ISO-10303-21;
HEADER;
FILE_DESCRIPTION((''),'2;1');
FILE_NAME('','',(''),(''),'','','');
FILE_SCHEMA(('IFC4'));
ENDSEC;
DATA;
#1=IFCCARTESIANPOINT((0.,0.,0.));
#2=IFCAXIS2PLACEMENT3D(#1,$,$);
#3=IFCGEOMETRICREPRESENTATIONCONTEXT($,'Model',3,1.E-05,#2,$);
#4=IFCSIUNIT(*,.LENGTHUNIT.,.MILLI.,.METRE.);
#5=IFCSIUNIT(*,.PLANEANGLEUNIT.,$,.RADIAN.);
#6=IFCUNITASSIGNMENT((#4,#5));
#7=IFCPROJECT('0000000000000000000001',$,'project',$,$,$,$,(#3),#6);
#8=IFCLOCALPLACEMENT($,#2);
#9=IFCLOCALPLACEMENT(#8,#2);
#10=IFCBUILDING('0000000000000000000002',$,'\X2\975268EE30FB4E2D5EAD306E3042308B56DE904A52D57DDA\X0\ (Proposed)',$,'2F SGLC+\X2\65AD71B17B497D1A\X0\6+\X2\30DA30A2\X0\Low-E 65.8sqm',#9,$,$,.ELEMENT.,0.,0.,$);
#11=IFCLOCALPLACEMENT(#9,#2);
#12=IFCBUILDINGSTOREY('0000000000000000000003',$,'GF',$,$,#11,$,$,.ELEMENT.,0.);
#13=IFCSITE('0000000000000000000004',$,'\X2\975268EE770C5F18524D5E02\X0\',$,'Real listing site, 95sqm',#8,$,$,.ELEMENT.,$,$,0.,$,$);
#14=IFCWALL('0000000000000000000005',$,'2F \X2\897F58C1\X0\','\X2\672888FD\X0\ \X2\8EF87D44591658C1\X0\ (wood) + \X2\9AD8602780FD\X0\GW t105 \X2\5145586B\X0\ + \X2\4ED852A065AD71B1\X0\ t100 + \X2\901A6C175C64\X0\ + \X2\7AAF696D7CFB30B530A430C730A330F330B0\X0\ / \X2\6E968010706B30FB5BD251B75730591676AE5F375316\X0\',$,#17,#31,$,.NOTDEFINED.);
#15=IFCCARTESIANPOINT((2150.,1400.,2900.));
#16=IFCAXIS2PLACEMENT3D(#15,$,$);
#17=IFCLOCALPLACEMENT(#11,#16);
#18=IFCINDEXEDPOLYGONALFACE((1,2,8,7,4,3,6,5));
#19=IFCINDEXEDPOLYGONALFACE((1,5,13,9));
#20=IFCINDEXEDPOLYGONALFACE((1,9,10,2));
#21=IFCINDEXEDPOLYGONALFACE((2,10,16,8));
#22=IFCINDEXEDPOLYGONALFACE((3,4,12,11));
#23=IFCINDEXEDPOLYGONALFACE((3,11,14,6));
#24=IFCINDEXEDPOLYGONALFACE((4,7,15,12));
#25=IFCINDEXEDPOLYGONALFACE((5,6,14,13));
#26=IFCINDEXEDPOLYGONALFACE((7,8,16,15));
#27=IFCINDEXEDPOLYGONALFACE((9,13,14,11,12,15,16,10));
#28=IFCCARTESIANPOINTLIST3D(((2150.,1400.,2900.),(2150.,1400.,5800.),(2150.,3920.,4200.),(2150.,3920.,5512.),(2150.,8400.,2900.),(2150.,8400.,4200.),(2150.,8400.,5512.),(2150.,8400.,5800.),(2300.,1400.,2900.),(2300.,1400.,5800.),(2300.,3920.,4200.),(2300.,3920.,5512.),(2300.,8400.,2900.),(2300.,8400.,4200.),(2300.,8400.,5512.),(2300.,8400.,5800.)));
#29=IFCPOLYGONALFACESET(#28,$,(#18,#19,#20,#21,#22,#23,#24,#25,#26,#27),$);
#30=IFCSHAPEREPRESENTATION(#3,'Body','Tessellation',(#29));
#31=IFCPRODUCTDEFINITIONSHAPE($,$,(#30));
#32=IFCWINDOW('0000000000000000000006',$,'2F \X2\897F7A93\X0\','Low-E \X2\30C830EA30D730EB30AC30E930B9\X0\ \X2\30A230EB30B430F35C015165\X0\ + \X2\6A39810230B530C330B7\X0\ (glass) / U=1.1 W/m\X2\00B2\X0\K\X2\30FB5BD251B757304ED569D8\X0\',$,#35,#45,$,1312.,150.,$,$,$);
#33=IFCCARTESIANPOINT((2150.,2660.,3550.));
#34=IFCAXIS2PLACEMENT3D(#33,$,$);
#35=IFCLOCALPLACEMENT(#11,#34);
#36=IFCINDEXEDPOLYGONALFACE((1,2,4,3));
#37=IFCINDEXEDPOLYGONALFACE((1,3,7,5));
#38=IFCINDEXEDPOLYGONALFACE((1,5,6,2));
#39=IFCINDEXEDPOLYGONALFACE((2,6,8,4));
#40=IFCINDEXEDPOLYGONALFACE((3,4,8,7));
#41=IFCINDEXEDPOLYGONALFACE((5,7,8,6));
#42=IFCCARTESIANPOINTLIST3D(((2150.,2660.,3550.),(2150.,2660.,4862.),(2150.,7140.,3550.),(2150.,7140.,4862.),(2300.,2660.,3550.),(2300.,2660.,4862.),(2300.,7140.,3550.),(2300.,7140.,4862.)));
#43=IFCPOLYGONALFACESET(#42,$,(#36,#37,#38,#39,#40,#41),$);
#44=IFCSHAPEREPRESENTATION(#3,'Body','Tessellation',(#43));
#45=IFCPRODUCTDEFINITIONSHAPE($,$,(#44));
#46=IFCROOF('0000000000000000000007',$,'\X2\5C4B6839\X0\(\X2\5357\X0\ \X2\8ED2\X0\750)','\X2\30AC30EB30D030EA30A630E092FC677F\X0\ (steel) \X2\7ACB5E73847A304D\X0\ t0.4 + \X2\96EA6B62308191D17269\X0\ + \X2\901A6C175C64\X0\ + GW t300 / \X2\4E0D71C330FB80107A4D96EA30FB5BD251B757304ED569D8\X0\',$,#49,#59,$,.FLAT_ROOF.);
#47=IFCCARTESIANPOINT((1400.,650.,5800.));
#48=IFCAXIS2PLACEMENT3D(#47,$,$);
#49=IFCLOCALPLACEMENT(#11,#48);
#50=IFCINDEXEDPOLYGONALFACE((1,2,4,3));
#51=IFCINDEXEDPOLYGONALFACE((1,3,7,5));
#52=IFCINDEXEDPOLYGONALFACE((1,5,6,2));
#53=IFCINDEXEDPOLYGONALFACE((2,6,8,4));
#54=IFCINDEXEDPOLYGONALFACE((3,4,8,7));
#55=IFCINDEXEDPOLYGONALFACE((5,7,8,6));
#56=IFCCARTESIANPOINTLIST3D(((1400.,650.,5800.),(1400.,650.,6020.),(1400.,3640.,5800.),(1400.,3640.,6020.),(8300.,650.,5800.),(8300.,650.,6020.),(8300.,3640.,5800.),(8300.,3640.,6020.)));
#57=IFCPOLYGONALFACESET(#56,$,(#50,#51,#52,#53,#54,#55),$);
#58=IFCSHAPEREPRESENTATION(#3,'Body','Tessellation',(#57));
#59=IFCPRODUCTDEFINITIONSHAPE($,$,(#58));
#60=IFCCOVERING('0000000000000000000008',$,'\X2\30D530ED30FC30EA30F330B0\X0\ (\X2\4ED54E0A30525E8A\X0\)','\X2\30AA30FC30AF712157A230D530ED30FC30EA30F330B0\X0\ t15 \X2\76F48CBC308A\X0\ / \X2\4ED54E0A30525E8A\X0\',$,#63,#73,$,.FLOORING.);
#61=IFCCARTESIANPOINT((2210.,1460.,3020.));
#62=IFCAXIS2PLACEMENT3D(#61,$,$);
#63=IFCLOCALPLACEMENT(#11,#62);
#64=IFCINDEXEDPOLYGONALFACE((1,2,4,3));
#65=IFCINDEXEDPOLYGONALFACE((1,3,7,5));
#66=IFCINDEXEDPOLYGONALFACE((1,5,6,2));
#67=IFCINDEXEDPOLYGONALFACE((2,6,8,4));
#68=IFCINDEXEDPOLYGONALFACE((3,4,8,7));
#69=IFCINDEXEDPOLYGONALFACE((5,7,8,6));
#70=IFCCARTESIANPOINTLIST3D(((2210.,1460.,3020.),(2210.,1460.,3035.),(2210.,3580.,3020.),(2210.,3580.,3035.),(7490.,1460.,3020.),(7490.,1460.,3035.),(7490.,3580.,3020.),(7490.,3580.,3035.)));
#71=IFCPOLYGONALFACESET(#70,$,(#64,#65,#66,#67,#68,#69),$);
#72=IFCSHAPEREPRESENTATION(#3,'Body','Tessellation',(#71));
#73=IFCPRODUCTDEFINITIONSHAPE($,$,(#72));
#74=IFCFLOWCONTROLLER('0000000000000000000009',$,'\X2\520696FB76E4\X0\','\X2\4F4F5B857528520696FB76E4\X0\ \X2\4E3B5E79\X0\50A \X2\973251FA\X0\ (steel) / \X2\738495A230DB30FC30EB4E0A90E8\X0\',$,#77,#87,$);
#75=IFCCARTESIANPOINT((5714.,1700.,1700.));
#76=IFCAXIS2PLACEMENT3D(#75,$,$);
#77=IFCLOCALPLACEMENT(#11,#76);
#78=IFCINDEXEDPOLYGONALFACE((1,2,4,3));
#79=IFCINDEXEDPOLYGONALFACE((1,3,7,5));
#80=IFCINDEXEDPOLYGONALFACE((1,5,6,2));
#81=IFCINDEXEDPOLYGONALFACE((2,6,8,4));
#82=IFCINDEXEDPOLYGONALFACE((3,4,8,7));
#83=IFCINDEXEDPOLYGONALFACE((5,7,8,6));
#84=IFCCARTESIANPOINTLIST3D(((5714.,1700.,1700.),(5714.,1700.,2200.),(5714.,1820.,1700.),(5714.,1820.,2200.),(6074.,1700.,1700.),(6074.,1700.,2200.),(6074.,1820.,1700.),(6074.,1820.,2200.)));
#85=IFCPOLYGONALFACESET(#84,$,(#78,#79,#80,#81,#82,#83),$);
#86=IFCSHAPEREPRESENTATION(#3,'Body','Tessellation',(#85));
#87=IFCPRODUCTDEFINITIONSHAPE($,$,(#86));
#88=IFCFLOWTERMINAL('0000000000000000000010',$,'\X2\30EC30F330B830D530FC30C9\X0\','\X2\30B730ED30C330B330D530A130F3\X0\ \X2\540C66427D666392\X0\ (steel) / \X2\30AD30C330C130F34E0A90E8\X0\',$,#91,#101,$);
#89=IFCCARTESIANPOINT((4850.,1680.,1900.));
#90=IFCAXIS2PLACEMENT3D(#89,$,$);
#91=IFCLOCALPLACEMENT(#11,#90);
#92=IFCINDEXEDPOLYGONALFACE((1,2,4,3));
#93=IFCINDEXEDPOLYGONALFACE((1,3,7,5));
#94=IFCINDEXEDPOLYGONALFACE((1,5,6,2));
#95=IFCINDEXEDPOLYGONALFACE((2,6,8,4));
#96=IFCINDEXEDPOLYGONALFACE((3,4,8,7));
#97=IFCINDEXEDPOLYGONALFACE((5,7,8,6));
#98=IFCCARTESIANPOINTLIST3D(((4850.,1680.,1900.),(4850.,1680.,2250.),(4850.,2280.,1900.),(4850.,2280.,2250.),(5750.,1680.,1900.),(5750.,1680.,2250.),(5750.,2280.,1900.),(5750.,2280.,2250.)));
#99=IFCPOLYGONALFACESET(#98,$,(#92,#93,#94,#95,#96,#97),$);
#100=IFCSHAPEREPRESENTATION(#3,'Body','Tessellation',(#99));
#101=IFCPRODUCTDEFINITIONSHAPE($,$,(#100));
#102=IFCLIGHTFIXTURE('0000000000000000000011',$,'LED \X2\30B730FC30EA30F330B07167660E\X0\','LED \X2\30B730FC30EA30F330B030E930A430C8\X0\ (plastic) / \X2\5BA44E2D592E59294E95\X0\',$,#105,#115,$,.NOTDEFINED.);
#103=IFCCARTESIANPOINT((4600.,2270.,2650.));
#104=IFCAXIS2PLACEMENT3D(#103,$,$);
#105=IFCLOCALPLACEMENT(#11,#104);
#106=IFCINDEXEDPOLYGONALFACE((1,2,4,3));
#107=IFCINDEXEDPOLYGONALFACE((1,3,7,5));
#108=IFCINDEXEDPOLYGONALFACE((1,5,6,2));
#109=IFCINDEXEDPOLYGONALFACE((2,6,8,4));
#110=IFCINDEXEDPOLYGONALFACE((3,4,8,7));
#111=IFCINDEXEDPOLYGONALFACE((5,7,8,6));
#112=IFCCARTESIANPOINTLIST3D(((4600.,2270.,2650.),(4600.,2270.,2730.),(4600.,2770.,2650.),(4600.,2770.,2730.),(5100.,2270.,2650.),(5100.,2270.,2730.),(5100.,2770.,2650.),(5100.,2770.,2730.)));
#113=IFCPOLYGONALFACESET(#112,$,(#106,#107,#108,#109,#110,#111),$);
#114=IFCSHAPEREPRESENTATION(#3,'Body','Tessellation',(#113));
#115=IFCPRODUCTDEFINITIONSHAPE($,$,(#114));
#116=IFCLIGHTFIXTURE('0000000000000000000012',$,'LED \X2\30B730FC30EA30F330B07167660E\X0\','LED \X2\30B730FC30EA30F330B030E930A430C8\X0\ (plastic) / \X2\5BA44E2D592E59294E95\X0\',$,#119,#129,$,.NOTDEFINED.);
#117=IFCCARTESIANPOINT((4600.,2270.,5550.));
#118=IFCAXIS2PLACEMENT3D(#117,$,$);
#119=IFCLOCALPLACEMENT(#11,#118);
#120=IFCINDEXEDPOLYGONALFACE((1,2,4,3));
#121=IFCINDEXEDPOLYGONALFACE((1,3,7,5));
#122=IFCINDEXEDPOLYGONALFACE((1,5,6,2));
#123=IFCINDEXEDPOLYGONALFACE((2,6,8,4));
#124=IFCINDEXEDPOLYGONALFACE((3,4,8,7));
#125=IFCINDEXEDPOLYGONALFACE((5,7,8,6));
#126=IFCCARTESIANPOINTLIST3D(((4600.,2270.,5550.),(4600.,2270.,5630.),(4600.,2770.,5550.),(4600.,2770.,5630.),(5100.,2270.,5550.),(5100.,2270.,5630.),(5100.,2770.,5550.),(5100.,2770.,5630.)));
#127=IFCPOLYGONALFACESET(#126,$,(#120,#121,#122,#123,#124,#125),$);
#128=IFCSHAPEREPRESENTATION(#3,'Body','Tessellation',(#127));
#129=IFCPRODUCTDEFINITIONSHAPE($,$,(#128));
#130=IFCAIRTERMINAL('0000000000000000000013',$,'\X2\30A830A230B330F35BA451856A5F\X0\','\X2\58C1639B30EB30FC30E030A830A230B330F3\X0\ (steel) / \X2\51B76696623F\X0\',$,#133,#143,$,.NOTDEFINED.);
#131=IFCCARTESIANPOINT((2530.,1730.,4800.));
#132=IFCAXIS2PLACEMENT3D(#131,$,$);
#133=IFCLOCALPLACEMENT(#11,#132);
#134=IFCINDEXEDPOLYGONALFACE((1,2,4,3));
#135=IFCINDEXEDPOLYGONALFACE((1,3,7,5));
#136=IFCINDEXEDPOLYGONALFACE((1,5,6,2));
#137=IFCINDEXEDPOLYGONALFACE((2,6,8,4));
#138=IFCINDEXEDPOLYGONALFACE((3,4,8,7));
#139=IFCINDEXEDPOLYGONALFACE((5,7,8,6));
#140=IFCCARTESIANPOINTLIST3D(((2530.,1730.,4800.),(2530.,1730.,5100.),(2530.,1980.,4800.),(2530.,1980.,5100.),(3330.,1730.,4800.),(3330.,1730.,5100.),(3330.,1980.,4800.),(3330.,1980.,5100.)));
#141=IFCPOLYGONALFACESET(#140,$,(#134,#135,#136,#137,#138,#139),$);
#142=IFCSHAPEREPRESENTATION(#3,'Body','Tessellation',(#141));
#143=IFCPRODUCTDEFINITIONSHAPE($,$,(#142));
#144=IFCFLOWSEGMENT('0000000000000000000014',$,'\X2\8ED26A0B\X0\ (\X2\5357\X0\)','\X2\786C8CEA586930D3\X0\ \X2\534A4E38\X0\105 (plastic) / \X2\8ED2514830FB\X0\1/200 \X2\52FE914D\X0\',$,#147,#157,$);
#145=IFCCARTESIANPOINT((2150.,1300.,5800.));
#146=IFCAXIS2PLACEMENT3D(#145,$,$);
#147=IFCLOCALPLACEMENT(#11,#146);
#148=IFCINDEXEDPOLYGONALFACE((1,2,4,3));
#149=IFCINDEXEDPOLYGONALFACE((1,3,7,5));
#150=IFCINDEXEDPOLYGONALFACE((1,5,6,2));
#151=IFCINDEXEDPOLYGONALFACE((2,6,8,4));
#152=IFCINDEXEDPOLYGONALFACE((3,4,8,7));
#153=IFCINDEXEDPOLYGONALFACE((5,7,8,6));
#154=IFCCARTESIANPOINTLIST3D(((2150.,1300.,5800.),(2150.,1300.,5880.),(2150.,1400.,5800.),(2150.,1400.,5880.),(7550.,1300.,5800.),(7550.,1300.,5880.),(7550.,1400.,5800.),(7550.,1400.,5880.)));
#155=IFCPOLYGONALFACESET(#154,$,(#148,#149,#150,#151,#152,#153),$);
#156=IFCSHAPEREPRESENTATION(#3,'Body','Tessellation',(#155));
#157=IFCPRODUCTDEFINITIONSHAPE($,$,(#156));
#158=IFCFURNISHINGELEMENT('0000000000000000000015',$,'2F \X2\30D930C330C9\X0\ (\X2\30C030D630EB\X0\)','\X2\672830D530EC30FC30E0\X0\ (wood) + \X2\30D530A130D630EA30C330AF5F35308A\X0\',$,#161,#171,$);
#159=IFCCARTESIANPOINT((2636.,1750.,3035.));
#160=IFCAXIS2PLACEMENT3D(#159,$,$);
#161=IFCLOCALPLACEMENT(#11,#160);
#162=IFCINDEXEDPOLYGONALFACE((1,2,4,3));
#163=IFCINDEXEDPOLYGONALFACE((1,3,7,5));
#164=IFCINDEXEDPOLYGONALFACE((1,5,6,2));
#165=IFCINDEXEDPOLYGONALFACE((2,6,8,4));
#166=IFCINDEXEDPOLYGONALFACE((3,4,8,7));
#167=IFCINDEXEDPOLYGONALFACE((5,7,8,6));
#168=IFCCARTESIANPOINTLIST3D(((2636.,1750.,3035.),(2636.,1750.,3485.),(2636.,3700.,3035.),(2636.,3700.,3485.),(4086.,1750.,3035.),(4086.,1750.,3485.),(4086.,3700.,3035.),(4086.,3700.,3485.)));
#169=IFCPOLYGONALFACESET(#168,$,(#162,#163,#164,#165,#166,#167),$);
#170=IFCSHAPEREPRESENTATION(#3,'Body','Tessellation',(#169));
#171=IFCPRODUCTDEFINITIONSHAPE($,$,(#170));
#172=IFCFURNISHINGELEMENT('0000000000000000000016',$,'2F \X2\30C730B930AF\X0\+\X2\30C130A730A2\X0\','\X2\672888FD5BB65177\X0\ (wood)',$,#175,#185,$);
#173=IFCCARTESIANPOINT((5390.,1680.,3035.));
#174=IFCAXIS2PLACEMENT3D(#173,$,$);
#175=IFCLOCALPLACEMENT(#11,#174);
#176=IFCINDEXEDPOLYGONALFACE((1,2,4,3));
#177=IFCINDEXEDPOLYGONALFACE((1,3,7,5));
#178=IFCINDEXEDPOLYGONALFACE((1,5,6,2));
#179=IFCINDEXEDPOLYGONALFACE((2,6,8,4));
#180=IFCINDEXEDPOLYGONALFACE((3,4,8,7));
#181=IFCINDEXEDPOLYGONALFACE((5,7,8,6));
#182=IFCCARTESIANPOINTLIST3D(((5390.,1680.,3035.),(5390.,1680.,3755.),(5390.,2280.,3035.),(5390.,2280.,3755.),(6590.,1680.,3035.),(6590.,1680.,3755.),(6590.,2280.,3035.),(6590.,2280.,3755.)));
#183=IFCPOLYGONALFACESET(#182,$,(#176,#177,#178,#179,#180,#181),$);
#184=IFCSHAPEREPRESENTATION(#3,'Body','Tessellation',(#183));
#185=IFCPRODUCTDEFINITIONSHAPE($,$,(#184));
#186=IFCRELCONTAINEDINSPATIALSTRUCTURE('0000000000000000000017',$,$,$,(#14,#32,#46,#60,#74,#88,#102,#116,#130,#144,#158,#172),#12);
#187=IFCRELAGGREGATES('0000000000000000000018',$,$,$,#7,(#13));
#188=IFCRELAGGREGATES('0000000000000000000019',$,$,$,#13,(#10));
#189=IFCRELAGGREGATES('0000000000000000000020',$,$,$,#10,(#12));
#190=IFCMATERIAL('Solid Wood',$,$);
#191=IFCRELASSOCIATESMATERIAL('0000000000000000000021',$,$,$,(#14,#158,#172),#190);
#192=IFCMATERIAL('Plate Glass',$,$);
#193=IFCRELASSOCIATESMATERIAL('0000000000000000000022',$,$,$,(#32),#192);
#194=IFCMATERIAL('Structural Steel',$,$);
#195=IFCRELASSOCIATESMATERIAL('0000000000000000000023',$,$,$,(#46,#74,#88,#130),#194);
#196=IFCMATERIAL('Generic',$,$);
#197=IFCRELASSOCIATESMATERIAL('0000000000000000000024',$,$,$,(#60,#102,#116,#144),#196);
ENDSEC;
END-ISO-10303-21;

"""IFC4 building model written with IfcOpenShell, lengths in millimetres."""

from ifc_helpers import new_model, si_unit, frame, frame_2d, origin, place, context, project, spatial, rectangle, extrude, material, element, fill, save


model = new_model("IFC4")

# Units and contexts
model_context = context("Model", 3, precision=1e-05, world=origin())
ifc_project = project(units=[si_unit("LENGTHUNIT", "METRE", prefix="MILLI"), si_unit("PLANEANGLEUNIT", "RADIAN")], contexts=[model_context])

# Site, building, storey
site_placement = place(None, origin())
site = spatial("IfcSite", under=ifc_project, at=site_placement, Name="青森県弘前市", ObjectType="Real listing site, 95sqm", CompositionType="ELEMENT", RefElevation=0.0)
building_placement = place(site_placement, origin())
building = spatial("IfcBuilding", under=site, at=building_placement, Name="青森・中庭のある回遊動線 (Proposed)", ObjectType="2F SGLC+断熱等級6+ペアLow-E 65.8sqm", CompositionType="ELEMENT", ElevationOfRefHeight=0.0, ElevationOfTerrain=0.0)
storey_placement = place(building_placement, origin())
storey = spatial("IfcBuildingStorey", under=building, at=storey_placement, Name="GF", CompositionType="ELEMENT", Elevation=0.0)

# Shared definitions
ifc_material_1 = material(Name="Solid Wood")

# Wall, opening, window
ifc_material_2 = material(Name="Plate Glass")
wall_1_placement = place(storey_placement, frame((2150.0, 1400.0, 2900.0)))
wall_1 = element("IfcWall", 1, at=wall_1_placement, inside=storey, material=ifc_material_1, Name="2F 西壁", Description="木製 軸組外壁 (wood) + 高性能GW t105 充填 + 付加断熱 t100 + 通気層 + 窯業系サイディング / 準耐火・寒冷地外皮強化", PredefinedType="NOTDEFINED", context=model_context, shape_type="SweptSolid", body=[
    extrude(rectangle(XDim=150.0, YDim=7000.0, at=frame_2d((75.0, 3500.0))), frame((2150.0, 1400.0, 2900.0)), (0.0, 0.0, 1.0), 2900.0),
])
opening_1_placement = place(storey_placement, frame((2150.0, 2660.0, 3550.0)))
opening_1 = element("IfcOpeningElement", 2, at=opening_1_placement, cuts=wall_1, PredefinedType="NOTDEFINED", context=model_context, shape_type="SweptSolid", body=[
    extrude(rectangle(XDim=150.0, YDim=4480.0, at=frame_2d((75.0, 2240.0))), frame((2150.0, 2660.0, 3550.0)), (0.0, 0.0, 1.0), 1312.0),
])
window_1_placement = place(storey_placement, frame((2150.0, 2660.0, 3550.0)))
window_1 = element("IfcWindow", 3, at=window_1_placement, inside=storey, material=ifc_material_2, Name="2F 西窓", Description="Low-E トリプルガラス アルゴン封入 + 樹脂サッシ (glass) / U=1.1 W/m²K・寒冷地仕様", OverallHeight=1312.0, OverallWidth=150.0, context=model_context, shape_type="SweptSolid", body=[
    extrude(rectangle(XDim=150.0, YDim=4480.0, at=frame_2d((75.0, 2240.0))), frame((2150.0, 2660.0, 3550.0)), (0.0, 0.0, 1.0), 1312.0),
])
fill(opening_1, window_1)

# Roof
ifc_material_3 = material(Name="Structural Steel")
for number, where, name in (
    (4, (1400.0, 650.0, 5800.0), "屋根(南 軒750)"),
):
    element("IfcRoof", number, at=place(storey_placement, frame(where)), inside=storey, material=ifc_material_3, Name=name, Description="ガルバリウム鋼板 (steel) 立平葺き t0.4 + 雪止め金物 + 通気層 + GW t300 / 不燃・耐積雪・寒冷地仕様", PredefinedType="FLAT_ROOF", context=model_context, shape_type="SweptSolid", body=[
        extrude(rectangle(XDim=6900.0, YDim=2990.0, at=frame_2d((3450.0, 1495.0))), frame((1400.0, 650.0, 5800.0)), (0.0, 0.0, 1.0), 220.0),
    ])

# Covering
ifc_material_4 = material(Name="Generic")
covering_placement = place(storey_placement, frame((2210.0, 1460.0, 3020.0)))
element("IfcCovering", 5, at=covering_placement, inside=storey, material=ifc_material_4, Name="フローリング (仕上げ床)", Description="オーク無垢フローリング t15 直貼り / 仕上げ床", PredefinedType="FLOORING", context=model_context, shape_type="SweptSolid", body=[
    extrude(rectangle(XDim=5280.0, YDim=2120.0, at=frame_2d((2640.0, 1060.0))), frame((2210.0, 1460.0, 3020.0)), (0.0, 0.0, 1.0), 15.0),
])

# Flow controller
flow_controller_placement = place(storey_placement, frame((5714.0, 1700.0, 1700.0)))
element("IfcFlowController", 6, at=flow_controller_placement, inside=storey, material=ifc_material_3, Name="分電盤", Description="住宅用分電盤 主幹50A 露出 (steel) / 玄関ホール上部", context=model_context, shape_type="SweptSolid", body=[
    extrude(rectangle(XDim=360.0, YDim=120.0, at=frame_2d((180.0, 60.0))), frame((5714.0, 1700.0, 1700.0)), (0.0, 0.0, 1.0), 500.0),
])

# Flow terminal
flow_terminal_placement = place(storey_placement, frame((4850.0, 1680.0, 1900.0)))
element("IfcFlowTerminal", 7, at=flow_terminal_placement, inside=storey, material=ifc_material_3, Name="レンジフード", Description="シロッコファン 同時給排 (steel) / キッチン上部", context=model_context, shape_type="SweptSolid", body=[
    extrude(rectangle(XDim=900.0, YDim=600.0, at=frame_2d((450.0, 300.0))), frame((4850.0, 1680.0, 1900.0)), (0.0, 0.0, 1.0), 350.0),
])

# Light fixtures
light_fixture_1_placement = place(storey_placement, frame((4600.0, 2270.0, 2650.0)))
element("IfcLightFixture", 8, at=light_fixture_1_placement, inside=storey, material=ifc_material_4, Name="LED シーリング照明", Description="LED シーリングライト (plastic) / 室中央天井", PredefinedType="NOTDEFINED", context=model_context, shape_type="SweptSolid", body=[
    extrude(rectangle(XDim=500.0, YDim=500.0, at=frame_2d((250.0, 250.0))), frame((4600.0, 2270.0, 2650.0)), (0.0, 0.0, 1.0), 80.0),
])
light_fixture_2_placement = place(storey_placement, frame((4600.0, 2270.0, 5550.0)))
element("IfcLightFixture", 9, at=light_fixture_2_placement, inside=storey, material=ifc_material_4, Name="LED シーリング照明", Description="LED シーリングライト (plastic) / 室中央天井", PredefinedType="NOTDEFINED", context=model_context, shape_type="SweptSolid", body=[
    extrude(rectangle(XDim=500.0, YDim=500.0, at=frame_2d((250.0, 250.0))), frame((4600.0, 2270.0, 5550.0)), (0.0, 0.0, 1.0), 80.0),
])

# Air terminal
air_terminal_placement = place(storey_placement, frame((2530.0, 1730.0, 4800.0)))
element("IfcAirTerminal", 10, at=air_terminal_placement, inside=storey, material=ifc_material_3, Name="エアコン室内機", Description="壁掛ルームエアコン (steel) / 冷暖房", PredefinedType="NOTDEFINED", context=model_context, shape_type="SweptSolid", body=[
    extrude(rectangle(XDim=800.0, YDim=250.0, at=frame_2d((400.0, 125.0))), frame((2530.0, 1730.0, 4800.0)), (0.0, 0.0, 1.0), 300.0),
])

# Flow segment
flow_segment_placement = place(storey_placement, frame((2150.0, 1300.0, 5800.0)))
element("IfcFlowSegment", 11, at=flow_segment_placement, inside=storey, material=ifc_material_4, Name="軒樋 (南)", Description="硬質塩ビ 半丸105 (plastic) / 軒先・1/200 勾配", context=model_context, shape_type="SweptSolid", body=[
    extrude(rectangle(XDim=5400.0, YDim=100.0, at=frame_2d((2700.0, 50.0))), frame((2150.0, 1300.0, 5800.0)), (0.0, 0.0, 1.0), 80.0),
])

# Furnishing elements
furnishing_1_placement = place(storey_placement, frame((2636.0, 1750.0, 3035.0)))
element("IfcFurnishingElement", 12, at=furnishing_1_placement, inside=storey, material=ifc_material_1, Name="2F ベッド (ダブル)", Description="木フレーム (wood) + ファブリック張り", context=model_context, shape_type="SweptSolid", body=[
    extrude(rectangle(XDim=1450.0, YDim=1950.0, at=frame_2d((725.0, 975.0))), frame((2636.0, 1750.0, 3035.0)), (0.0, 0.0, 1.0), 450.0),
])
furnishing_2_placement = place(storey_placement, frame((5390.0, 1680.0, 3035.0)))
element("IfcFurnishingElement", 13, at=furnishing_2_placement, inside=storey, material=ifc_material_1, Name="2F デスク+チェア", Description="木製家具 (wood)", context=model_context, shape_type="SweptSolid", body=[
    extrude(rectangle(XDim=1200.0, YDim=600.0, at=frame_2d((600.0, 300.0))), frame((5390.0, 1680.0, 3035.0)), (0.0, 0.0, 1.0), 720.0),
])

save(model, "model.ifc")
